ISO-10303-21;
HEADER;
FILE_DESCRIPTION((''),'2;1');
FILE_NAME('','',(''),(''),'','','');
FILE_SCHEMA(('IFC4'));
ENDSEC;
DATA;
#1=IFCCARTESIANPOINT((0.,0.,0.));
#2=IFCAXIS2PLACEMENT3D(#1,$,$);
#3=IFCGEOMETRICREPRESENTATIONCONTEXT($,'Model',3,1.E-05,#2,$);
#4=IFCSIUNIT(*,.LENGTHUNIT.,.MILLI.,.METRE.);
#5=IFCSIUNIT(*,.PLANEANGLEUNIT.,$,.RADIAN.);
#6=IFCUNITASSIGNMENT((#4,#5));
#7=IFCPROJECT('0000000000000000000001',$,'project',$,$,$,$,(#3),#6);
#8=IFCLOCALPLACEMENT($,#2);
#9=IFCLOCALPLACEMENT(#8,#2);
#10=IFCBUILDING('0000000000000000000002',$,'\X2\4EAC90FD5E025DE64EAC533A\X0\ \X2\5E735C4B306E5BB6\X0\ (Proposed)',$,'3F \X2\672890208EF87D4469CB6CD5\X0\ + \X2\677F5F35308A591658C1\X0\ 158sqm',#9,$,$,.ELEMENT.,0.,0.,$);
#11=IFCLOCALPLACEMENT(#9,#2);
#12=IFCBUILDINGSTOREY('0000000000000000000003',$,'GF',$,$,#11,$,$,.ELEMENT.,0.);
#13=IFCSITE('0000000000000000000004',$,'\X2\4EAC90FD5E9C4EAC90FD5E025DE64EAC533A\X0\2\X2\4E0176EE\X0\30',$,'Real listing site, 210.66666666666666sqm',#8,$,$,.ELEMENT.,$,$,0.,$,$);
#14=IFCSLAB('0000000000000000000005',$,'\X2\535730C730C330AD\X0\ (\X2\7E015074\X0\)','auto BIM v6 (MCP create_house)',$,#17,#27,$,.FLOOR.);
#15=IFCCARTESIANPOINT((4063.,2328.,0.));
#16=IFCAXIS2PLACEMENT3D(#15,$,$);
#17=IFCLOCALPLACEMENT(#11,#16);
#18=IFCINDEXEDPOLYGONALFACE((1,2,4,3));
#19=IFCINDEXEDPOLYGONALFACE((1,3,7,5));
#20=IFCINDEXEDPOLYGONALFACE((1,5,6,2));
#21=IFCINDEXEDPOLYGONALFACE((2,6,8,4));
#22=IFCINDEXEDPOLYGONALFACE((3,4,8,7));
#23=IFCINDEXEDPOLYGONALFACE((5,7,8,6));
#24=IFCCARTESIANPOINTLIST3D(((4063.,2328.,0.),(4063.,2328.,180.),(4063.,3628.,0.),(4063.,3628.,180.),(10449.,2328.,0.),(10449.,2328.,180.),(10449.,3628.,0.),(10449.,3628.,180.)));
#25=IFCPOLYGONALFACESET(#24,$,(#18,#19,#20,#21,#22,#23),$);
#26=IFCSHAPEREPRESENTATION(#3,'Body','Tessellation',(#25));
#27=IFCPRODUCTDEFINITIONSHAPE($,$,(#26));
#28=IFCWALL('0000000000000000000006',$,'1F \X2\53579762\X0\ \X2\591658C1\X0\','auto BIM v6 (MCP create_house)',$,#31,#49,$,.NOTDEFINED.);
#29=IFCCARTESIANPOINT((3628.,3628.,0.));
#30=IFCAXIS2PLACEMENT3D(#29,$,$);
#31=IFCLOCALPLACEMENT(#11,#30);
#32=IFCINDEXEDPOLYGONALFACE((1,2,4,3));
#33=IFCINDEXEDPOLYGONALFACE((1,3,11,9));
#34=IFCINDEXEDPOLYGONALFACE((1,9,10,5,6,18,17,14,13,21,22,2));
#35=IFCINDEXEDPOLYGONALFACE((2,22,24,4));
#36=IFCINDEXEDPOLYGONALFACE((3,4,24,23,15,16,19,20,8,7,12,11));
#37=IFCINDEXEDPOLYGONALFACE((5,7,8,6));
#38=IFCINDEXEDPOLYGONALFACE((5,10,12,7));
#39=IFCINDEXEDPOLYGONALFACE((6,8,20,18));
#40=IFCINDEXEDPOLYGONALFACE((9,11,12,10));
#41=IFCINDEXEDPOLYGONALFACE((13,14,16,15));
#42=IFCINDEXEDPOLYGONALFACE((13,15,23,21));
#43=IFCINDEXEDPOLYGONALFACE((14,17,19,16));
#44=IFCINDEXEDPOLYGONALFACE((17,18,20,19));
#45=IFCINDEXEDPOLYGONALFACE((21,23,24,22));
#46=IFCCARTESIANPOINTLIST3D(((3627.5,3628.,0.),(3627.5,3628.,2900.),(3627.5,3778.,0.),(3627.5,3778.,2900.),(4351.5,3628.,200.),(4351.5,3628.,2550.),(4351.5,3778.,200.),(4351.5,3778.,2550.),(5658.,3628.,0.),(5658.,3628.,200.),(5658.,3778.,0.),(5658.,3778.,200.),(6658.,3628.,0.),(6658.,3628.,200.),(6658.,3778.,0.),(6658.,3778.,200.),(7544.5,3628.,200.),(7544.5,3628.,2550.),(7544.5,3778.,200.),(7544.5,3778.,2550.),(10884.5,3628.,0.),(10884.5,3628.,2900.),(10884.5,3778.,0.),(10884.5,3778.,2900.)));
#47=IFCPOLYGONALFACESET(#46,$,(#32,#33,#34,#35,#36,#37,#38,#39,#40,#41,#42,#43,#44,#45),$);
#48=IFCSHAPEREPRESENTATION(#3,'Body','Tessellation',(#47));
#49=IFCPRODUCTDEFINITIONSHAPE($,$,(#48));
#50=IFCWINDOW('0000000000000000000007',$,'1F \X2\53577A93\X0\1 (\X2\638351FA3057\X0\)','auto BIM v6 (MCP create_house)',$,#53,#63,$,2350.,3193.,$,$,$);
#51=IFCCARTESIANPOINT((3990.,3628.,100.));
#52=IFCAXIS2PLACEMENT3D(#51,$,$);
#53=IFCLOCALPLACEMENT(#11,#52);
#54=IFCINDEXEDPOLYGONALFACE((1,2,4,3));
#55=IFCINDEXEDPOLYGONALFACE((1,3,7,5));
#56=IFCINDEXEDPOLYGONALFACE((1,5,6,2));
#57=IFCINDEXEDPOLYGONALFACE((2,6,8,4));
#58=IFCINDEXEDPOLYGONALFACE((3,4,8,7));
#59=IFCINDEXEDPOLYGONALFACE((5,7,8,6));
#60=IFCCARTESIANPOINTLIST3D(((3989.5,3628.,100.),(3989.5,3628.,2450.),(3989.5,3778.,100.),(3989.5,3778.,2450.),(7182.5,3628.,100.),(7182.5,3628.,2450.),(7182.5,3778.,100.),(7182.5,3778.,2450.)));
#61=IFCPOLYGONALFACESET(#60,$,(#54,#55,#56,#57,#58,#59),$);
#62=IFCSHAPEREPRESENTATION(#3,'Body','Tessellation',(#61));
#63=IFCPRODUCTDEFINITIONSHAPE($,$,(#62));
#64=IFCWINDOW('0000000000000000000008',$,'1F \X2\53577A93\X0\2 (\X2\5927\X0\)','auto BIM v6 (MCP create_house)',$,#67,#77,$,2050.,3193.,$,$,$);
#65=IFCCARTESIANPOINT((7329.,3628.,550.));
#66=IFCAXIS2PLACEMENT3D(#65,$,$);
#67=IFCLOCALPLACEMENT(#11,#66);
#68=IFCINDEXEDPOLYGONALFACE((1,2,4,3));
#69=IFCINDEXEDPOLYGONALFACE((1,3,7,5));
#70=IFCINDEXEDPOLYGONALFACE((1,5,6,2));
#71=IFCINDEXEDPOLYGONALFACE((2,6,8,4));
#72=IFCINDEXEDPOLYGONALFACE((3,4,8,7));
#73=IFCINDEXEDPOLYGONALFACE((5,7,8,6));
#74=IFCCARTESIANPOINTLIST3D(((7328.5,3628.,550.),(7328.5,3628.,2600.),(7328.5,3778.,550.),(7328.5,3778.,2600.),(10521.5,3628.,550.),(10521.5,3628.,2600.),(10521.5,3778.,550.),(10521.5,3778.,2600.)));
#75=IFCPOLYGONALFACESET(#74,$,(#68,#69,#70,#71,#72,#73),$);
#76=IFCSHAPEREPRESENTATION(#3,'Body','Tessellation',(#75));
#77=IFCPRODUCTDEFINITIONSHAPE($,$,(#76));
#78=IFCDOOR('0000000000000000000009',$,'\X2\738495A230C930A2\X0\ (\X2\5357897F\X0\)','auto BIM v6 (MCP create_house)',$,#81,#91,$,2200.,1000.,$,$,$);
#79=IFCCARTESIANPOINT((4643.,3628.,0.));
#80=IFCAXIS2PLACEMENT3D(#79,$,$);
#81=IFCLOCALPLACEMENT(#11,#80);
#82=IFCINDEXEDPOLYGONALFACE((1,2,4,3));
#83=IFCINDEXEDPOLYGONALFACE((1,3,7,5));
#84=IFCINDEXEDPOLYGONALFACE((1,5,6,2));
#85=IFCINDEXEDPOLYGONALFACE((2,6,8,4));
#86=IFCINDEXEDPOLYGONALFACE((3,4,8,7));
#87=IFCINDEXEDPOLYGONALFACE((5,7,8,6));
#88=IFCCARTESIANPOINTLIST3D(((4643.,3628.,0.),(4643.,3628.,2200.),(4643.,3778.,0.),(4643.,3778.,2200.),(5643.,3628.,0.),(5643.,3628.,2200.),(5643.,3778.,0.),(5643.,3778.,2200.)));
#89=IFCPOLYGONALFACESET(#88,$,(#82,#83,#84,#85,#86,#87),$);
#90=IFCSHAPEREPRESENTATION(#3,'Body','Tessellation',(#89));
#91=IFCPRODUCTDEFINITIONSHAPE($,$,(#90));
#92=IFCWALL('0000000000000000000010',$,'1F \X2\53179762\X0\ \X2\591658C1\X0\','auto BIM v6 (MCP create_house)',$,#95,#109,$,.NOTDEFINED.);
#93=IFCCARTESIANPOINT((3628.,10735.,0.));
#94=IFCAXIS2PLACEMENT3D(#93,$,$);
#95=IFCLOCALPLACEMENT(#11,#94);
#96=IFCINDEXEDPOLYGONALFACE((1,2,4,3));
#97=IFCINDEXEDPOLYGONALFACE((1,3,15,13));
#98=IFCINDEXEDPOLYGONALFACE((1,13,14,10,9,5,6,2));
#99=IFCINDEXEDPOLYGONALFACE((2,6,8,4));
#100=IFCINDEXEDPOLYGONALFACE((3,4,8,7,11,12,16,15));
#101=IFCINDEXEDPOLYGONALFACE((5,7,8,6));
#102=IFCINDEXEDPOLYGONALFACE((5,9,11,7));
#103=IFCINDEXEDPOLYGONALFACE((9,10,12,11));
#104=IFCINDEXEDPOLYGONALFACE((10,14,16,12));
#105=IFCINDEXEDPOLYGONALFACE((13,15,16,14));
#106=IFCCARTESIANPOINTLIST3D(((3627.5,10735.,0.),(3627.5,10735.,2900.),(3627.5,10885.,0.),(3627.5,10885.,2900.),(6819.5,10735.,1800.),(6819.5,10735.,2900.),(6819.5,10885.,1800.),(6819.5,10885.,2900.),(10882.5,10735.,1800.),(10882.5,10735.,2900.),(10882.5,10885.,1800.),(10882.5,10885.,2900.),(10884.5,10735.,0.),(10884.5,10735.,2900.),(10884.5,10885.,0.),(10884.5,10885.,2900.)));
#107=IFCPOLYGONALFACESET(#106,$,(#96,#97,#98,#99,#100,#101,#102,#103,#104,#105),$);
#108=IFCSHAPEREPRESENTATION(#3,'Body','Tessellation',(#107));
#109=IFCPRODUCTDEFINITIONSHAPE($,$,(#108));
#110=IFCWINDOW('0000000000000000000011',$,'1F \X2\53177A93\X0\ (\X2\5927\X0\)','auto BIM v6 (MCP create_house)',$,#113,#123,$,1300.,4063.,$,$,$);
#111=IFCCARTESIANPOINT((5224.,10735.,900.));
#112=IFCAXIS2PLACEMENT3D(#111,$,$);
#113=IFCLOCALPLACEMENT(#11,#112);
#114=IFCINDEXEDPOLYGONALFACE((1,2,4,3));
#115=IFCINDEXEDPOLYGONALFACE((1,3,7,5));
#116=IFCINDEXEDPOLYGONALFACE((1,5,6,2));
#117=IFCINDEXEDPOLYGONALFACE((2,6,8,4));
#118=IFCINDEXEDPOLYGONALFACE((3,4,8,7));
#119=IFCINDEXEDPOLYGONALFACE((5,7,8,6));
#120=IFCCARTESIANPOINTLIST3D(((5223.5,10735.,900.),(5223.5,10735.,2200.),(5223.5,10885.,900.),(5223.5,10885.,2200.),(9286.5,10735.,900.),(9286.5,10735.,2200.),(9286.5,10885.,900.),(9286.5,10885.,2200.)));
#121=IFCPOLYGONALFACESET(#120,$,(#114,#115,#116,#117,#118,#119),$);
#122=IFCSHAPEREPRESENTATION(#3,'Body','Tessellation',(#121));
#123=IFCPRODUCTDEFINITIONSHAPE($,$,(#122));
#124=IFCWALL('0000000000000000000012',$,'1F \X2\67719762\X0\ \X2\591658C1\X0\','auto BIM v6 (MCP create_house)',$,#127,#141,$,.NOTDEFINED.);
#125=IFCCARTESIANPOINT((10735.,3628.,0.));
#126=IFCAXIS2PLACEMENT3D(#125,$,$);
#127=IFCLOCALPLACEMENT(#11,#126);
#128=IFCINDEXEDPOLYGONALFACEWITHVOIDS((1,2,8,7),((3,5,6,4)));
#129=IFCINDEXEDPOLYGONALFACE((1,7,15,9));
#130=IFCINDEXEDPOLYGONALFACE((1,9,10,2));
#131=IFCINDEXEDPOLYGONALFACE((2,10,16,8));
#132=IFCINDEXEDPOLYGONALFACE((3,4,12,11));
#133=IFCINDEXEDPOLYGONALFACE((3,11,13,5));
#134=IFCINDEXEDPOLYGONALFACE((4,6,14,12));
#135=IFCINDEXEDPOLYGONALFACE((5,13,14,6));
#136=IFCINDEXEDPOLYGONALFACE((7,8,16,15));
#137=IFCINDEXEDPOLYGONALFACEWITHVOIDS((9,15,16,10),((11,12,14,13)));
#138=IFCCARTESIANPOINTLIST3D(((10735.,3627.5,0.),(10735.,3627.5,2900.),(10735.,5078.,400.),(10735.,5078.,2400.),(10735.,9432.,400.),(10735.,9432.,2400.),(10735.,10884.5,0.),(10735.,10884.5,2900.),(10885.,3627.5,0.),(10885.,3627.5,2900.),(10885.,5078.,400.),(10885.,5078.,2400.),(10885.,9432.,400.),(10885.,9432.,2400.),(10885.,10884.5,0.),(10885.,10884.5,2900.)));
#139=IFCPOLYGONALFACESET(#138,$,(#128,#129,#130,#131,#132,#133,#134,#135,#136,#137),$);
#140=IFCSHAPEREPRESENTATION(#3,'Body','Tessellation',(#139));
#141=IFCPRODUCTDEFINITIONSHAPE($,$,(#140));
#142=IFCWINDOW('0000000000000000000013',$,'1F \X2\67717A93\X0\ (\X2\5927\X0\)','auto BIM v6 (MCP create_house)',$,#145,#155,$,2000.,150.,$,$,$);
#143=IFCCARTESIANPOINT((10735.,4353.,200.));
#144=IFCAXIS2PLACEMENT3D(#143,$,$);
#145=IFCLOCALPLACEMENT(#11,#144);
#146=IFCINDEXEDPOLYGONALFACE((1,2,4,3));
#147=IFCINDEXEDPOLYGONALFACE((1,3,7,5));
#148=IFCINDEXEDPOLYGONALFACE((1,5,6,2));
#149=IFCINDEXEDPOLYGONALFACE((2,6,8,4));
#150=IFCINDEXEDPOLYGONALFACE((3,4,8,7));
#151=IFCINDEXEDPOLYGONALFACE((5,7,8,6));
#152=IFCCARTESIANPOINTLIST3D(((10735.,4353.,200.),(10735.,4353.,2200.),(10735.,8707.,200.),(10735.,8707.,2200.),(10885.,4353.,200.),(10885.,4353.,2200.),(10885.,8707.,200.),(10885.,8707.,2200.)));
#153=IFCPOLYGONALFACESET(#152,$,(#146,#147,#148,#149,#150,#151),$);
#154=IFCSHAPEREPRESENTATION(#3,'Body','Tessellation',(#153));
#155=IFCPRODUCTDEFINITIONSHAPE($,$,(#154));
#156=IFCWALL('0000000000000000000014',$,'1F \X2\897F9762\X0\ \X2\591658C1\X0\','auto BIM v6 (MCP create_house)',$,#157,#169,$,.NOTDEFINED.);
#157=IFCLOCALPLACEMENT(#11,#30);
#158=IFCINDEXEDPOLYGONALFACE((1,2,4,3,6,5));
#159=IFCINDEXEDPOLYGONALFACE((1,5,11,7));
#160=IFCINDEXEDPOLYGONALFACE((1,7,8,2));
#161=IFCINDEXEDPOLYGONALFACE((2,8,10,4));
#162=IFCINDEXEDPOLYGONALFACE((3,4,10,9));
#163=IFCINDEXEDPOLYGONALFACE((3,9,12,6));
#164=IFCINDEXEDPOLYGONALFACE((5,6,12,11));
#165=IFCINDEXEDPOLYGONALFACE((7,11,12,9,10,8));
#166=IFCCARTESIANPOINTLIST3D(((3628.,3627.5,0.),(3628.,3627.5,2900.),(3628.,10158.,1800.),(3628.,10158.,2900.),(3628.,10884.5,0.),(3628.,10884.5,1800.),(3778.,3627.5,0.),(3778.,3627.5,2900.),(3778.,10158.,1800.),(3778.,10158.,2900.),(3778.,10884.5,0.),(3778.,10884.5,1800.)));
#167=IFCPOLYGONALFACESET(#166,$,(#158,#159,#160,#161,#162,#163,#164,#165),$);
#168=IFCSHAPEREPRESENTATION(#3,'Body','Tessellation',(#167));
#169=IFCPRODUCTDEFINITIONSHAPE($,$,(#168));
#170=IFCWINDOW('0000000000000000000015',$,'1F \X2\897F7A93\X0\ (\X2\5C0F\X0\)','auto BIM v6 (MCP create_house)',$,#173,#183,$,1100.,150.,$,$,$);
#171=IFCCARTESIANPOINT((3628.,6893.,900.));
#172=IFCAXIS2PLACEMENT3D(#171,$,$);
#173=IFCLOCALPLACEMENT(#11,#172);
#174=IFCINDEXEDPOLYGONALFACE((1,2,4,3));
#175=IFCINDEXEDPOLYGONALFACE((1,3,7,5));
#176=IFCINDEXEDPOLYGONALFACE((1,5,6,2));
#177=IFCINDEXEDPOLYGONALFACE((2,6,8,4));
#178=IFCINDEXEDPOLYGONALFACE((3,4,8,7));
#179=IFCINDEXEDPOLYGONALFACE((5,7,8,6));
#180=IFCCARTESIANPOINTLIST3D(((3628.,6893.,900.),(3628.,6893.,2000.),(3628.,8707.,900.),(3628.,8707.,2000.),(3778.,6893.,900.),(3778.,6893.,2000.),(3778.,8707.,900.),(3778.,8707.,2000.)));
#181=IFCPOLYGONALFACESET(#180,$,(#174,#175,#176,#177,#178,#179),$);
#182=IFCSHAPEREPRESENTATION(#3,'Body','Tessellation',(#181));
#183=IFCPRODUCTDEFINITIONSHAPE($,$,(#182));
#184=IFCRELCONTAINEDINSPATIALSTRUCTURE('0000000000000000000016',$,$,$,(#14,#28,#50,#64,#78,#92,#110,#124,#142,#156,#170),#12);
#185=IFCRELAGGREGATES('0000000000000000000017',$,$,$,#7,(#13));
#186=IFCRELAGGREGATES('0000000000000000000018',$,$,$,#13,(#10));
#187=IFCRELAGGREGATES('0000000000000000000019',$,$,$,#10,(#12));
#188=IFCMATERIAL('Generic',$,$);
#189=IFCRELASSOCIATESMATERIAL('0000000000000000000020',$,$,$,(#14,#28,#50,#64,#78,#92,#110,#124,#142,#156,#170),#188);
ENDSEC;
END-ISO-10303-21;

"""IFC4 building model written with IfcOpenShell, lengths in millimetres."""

from ifc_helpers import new_model, si_unit, frame, frame_2d, origin, place, context, project, spatial, rectangle, extrude, material, element, fill, save


model = new_model("IFC4")

# Units and contexts
model_context = context("Model", 3, precision=1e-05, world=origin())
ifc_project = project(units=[si_unit("LENGTHUNIT", "METRE", prefix="MILLI"), si_unit("PLANEANGLEUNIT", "RADIAN")], contexts=[model_context])

# Site, building, storey
site_placement = place(None, origin())
site = spatial("IfcSite", under=ifc_project, at=site_placement, Name="京都府京都市左京区2丁目30", ObjectType="Real listing site, 210.66666666666666sqm", CompositionType="ELEMENT", RefElevation=0.0)
building_placement = place(site_placement, origin())
building = spatial("IfcBuilding", under=site, at=building_placement, Name="京都市左京区 平屋の家 (Proposed)", ObjectType="3F 木造軸組構法 + 板張り外壁 158sqm", CompositionType="ELEMENT", ElevationOfRefHeight=0.0, ElevationOfTerrain=0.0)
storey_placement = place(building_placement, origin())
storey = spatial("IfcBuildingStorey", under=building, at=storey_placement, Name="GF", CompositionType="ELEMENT", Elevation=0.0)

# Slab
ifc_material = material(Name="Generic")
slab_1_placement = place(storey_placement, frame((4063.0, 2328.0, 0.0)))
element("IfcSlab", 1, at=slab_1_placement, inside=storey, material=ifc_material, Name="南デッキ (縁側)", Description="auto BIM v6 (MCP create_house)", PredefinedType="FLOOR", context=model_context, shape_type="SweptSolid", body=[
    extrude(rectangle(XDim=6386.0, YDim=1300.0, at=frame_2d((3193.0, 650.0))), frame((4063.0, 2328.0, 0.0)), (0.0, 0.0, 1.0), 180.0),
])

# Wall, openings, windows, door
wall_1_placement = place(storey_placement, frame((3628.0, 3628.0, 0.0)))
wall_1 = element("IfcWall", 2, at=wall_1_placement, inside=storey, material=ifc_material, Name="1F 南面 外壁", Description="auto BIM v6 (MCP create_house)", PredefinedType="NOTDEFINED", context=model_context, shape_type="SweptSolid", body=[
    extrude(rectangle(XDim=7257.0, YDim=150.0, at=frame_2d((3628.0, 75.0))), frame((3628.0, 3628.0, 0.0)), (0.0, 0.0, 1.0), 2900.0),
])
opening_1_placement = place(storey_placement, frame((3990.0, 3628.0, 100.0)))
opening_1 = element("IfcOpeningElement", 3, at=opening_1_placement, cuts=wall_1, PredefinedType="NOTDEFINED", context=model_context, shape_type="SweptSolid", body=[
    extrude(rectangle(XDim=3193.0, YDim=150.0, at=frame_2d((1596.0, 75.0))), frame((3990.0, 3628.0, 100.0)), (0.0, 0.0, 1.0), 2350.0),
])
opening_2_placement = place(storey_placement, frame((7329.0, 3628.0, 550.0)))
opening_2 = element("IfcOpeningElement", 4, at=opening_2_placement, cuts=wall_1, PredefinedType="NOTDEFINED", context=model_context, shape_type="SweptSolid", body=[
    extrude(rectangle(XDim=3193.0, YDim=150.0, at=frame_2d((1596.0, 75.0))), frame((7329.0, 3628.0, 550.0)), (0.0, 0.0, 1.0), 2050.0),
])
opening_3_placement = place(storey_placement, frame((4643.0, 3628.0, 0.0)))
opening_3 = element("IfcOpeningElement", 5, at=opening_3_placement, cuts=wall_1, PredefinedType="NOTDEFINED", context=model_context, shape_type="SweptSolid", body=[
    extrude(rectangle(XDim=1000.0, YDim=150.0, at=frame_2d((500.0, 75.0))), frame((4643.0, 3628.0, 0.0)), (0.0, 0.0, 1.0), 2200.0),
])
window_1_placement = place(storey_placement, frame((3990.0, 3628.0, 100.0)))
window_1 = element("IfcWindow", 6, at=window_1_placement, inside=storey, material=ifc_material, Name="1F 南窓1 (掃出し)", Description="auto BIM v6 (MCP create_house)", OverallHeight=2350.0, OverallWidth=3193.0, context=model_context, shape_type="SweptSolid", body=[
    extrude(rectangle(XDim=3193.0, YDim=150.0, at=frame_2d((1596.0, 75.0))), frame((3990.0, 3628.0, 100.0)), (0.0, 0.0, 1.0), 2350.0),
])
fill(opening_1, window_1)
window_2_placement = place(storey_placement, frame((7329.0, 3628.0, 550.0)))
window_2 = element("IfcWindow", 7, at=window_2_placement, inside=storey, material=ifc_material, Name="1F 南窓2 (大)", Description="auto BIM v6 (MCP create_house)", OverallHeight=2050.0, OverallWidth=3193.0, context=model_context, shape_type="SweptSolid", body=[
    extrude(rectangle(XDim=3193.0, YDim=150.0, at=frame_2d((1596.0, 75.0))), frame((7329.0, 3628.0, 550.0)), (0.0, 0.0, 1.0), 2050.0),
])
fill(opening_2, window_2)
door_placement = place(storey_placement, frame((4643.0, 3628.0, 0.0)))
door = element("IfcDoor", 8, at=door_placement, inside=storey, material=ifc_material, Name="玄関ドア (南西)", Description="auto BIM v6 (MCP create_house)", OverallHeight=2200.0, OverallWidth=1000.0, context=model_context, shape_type="SweptSolid", body=[
    extrude(rectangle(XDim=1000.0, YDim=150.0, at=frame_2d((500.0, 75.0))), frame((4643.0, 3628.0, 0.0)), (0.0, 0.0, 1.0), 2200.0),
])
fill(opening_3, door)

# Walls, openings, windows
wall_2_placement = place(storey_placement, frame((3628.0, 10735.0, 0.0)))
wall_2 = element("IfcWall", 9, at=wall_2_placement, inside=storey, material=ifc_material, Name="1F 北面 外壁", Description="auto BIM v6 (MCP create_house)", PredefinedType="NOTDEFINED", context=model_context, shape_type="SweptSolid", body=[
    extrude(rectangle(XDim=7257.0, YDim=150.0, at=frame_2d((3628.0, 75.0))), frame((3628.0, 10735.0, 0.0)), (0.0, 0.0, 1.0), 2900.0),
])
opening_4_placement = place(storey_placement, frame((5224.0, 10735.0, 900.0)))
opening_4 = element("IfcOpeningElement", 10, at=opening_4_placement, cuts=wall_2, PredefinedType="NOTDEFINED", context=model_context, shape_type="SweptSolid", body=[
    extrude(rectangle(XDim=4063.0, YDim=150.0, at=frame_2d((2031.0, 75.0))), frame((5224.0, 10735.0, 900.0)), (0.0, 0.0, 1.0), 1300.0),
])
window_3_placement = place(storey_placement, frame((5224.0, 10735.0, 900.0)))
window_3 = element("IfcWindow", 11, at=window_3_placement, inside=storey, material=ifc_material, Name="1F 北窓 (大)", Description="auto BIM v6 (MCP create_house)", OverallHeight=1300.0, OverallWidth=4063.0, context=model_context, shape_type="SweptSolid", body=[
    extrude(rectangle(XDim=4063.0, YDim=150.0, at=frame_2d((2031.0, 75.0))), frame((5224.0, 10735.0, 900.0)), (0.0, 0.0, 1.0), 1300.0),
])
fill(opening_4, window_3)
wall_3_placement = place(storey_placement, frame((10735.0, 3628.0, 0.0)))
wall_3 = element("IfcWall", 12, at=wall_3_placement, inside=storey, material=ifc_material, Name="1F 東面 外壁", Description="auto BIM v6 (MCP create_house)", PredefinedType="NOTDEFINED", context=model_context, shape_type="SweptSolid", body=[
    extrude(rectangle(XDim=150.0, YDim=7257.0, at=frame_2d((75.0, 3628.0))), frame((10735.0, 3628.0, 0.0)), (0.0, 0.0, 1.0), 2900.0),
])
opening_5_placement = place(storey_placement, frame((10735.0, 4353.0, 200.0)))
opening_5 = element("IfcOpeningElement", 13, at=opening_5_placement, cuts=wall_3, PredefinedType="NOTDEFINED", context=model_context, shape_type="SweptSolid", body=[
    extrude(rectangle(XDim=150.0, YDim=4354.0, at=frame_2d((75.0, 2177.0))), frame((10735.0, 4353.0, 200.0)), (0.0, 0.0, 1.0), 2000.0),
])
window_4_placement = place(storey_placement, frame((10735.0, 4353.0, 200.0)))
window_4 = element("IfcWindow", 14, at=window_4_placement, inside=storey, material=ifc_material, Name="1F 東窓 (大)", Description="auto BIM v6 (MCP create_house)", OverallHeight=2000.0, OverallWidth=150.0, context=model_context, shape_type="SweptSolid", body=[
    extrude(rectangle(XDim=150.0, YDim=4354.0, at=frame_2d((75.0, 2177.0))), frame((10735.0, 4353.0, 200.0)), (0.0, 0.0, 1.0), 2000.0),
])
fill(opening_5, window_4)
wall_4_placement = place(storey_placement, frame((3628.0, 3628.0, 0.0)))
wall_4 = element("IfcWall", 15, at=wall_4_placement, inside=storey, material=ifc_material, Name="1F 西面 外壁", Description="auto BIM v6 (MCP create_house)", PredefinedType="NOTDEFINED", context=model_context, shape_type="SweptSolid", body=[
    extrude(rectangle(XDim=150.0, YDim=7257.0, at=frame_2d((75.0, 3628.0))), frame((3628.0, 3628.0, 0.0)), (0.0, 0.0, 1.0), 2900.0),
])
opening_6_placement = place(storey_placement, frame((3628.0, 6893.0, 900.0)))
opening_6 = element("IfcOpeningElement", 16, at=opening_6_placement, cuts=wall_4, PredefinedType="NOTDEFINED", context=model_context, shape_type="SweptSolid", body=[
    extrude(rectangle(XDim=150.0, YDim=1814.0, at=frame_2d((75.0, 907.0))), frame((3628.0, 6893.0, 900.0)), (0.0, 0.0, 1.0), 1100.0),
])
window_5_placement = place(storey_placement, frame((3628.0, 6893.0, 900.0)))
window_5 = element("IfcWindow", 17, at=window_5_placement, inside=storey, material=ifc_material, Name="1F 西窓 (小)", Description="auto BIM v6 (MCP create_house)", OverallHeight=1100.0, OverallWidth=150.0, context=model_context, shape_type="SweptSolid", body=[
    extrude(rectangle(XDim=150.0, YDim=1814.0, at=frame_2d((75.0, 907.0))), frame((3628.0, 6893.0, 900.0)), (0.0, 0.0, 1.0), 1100.0),
])
fill(opening_6, window_5)

save(model, "model.ifc")
